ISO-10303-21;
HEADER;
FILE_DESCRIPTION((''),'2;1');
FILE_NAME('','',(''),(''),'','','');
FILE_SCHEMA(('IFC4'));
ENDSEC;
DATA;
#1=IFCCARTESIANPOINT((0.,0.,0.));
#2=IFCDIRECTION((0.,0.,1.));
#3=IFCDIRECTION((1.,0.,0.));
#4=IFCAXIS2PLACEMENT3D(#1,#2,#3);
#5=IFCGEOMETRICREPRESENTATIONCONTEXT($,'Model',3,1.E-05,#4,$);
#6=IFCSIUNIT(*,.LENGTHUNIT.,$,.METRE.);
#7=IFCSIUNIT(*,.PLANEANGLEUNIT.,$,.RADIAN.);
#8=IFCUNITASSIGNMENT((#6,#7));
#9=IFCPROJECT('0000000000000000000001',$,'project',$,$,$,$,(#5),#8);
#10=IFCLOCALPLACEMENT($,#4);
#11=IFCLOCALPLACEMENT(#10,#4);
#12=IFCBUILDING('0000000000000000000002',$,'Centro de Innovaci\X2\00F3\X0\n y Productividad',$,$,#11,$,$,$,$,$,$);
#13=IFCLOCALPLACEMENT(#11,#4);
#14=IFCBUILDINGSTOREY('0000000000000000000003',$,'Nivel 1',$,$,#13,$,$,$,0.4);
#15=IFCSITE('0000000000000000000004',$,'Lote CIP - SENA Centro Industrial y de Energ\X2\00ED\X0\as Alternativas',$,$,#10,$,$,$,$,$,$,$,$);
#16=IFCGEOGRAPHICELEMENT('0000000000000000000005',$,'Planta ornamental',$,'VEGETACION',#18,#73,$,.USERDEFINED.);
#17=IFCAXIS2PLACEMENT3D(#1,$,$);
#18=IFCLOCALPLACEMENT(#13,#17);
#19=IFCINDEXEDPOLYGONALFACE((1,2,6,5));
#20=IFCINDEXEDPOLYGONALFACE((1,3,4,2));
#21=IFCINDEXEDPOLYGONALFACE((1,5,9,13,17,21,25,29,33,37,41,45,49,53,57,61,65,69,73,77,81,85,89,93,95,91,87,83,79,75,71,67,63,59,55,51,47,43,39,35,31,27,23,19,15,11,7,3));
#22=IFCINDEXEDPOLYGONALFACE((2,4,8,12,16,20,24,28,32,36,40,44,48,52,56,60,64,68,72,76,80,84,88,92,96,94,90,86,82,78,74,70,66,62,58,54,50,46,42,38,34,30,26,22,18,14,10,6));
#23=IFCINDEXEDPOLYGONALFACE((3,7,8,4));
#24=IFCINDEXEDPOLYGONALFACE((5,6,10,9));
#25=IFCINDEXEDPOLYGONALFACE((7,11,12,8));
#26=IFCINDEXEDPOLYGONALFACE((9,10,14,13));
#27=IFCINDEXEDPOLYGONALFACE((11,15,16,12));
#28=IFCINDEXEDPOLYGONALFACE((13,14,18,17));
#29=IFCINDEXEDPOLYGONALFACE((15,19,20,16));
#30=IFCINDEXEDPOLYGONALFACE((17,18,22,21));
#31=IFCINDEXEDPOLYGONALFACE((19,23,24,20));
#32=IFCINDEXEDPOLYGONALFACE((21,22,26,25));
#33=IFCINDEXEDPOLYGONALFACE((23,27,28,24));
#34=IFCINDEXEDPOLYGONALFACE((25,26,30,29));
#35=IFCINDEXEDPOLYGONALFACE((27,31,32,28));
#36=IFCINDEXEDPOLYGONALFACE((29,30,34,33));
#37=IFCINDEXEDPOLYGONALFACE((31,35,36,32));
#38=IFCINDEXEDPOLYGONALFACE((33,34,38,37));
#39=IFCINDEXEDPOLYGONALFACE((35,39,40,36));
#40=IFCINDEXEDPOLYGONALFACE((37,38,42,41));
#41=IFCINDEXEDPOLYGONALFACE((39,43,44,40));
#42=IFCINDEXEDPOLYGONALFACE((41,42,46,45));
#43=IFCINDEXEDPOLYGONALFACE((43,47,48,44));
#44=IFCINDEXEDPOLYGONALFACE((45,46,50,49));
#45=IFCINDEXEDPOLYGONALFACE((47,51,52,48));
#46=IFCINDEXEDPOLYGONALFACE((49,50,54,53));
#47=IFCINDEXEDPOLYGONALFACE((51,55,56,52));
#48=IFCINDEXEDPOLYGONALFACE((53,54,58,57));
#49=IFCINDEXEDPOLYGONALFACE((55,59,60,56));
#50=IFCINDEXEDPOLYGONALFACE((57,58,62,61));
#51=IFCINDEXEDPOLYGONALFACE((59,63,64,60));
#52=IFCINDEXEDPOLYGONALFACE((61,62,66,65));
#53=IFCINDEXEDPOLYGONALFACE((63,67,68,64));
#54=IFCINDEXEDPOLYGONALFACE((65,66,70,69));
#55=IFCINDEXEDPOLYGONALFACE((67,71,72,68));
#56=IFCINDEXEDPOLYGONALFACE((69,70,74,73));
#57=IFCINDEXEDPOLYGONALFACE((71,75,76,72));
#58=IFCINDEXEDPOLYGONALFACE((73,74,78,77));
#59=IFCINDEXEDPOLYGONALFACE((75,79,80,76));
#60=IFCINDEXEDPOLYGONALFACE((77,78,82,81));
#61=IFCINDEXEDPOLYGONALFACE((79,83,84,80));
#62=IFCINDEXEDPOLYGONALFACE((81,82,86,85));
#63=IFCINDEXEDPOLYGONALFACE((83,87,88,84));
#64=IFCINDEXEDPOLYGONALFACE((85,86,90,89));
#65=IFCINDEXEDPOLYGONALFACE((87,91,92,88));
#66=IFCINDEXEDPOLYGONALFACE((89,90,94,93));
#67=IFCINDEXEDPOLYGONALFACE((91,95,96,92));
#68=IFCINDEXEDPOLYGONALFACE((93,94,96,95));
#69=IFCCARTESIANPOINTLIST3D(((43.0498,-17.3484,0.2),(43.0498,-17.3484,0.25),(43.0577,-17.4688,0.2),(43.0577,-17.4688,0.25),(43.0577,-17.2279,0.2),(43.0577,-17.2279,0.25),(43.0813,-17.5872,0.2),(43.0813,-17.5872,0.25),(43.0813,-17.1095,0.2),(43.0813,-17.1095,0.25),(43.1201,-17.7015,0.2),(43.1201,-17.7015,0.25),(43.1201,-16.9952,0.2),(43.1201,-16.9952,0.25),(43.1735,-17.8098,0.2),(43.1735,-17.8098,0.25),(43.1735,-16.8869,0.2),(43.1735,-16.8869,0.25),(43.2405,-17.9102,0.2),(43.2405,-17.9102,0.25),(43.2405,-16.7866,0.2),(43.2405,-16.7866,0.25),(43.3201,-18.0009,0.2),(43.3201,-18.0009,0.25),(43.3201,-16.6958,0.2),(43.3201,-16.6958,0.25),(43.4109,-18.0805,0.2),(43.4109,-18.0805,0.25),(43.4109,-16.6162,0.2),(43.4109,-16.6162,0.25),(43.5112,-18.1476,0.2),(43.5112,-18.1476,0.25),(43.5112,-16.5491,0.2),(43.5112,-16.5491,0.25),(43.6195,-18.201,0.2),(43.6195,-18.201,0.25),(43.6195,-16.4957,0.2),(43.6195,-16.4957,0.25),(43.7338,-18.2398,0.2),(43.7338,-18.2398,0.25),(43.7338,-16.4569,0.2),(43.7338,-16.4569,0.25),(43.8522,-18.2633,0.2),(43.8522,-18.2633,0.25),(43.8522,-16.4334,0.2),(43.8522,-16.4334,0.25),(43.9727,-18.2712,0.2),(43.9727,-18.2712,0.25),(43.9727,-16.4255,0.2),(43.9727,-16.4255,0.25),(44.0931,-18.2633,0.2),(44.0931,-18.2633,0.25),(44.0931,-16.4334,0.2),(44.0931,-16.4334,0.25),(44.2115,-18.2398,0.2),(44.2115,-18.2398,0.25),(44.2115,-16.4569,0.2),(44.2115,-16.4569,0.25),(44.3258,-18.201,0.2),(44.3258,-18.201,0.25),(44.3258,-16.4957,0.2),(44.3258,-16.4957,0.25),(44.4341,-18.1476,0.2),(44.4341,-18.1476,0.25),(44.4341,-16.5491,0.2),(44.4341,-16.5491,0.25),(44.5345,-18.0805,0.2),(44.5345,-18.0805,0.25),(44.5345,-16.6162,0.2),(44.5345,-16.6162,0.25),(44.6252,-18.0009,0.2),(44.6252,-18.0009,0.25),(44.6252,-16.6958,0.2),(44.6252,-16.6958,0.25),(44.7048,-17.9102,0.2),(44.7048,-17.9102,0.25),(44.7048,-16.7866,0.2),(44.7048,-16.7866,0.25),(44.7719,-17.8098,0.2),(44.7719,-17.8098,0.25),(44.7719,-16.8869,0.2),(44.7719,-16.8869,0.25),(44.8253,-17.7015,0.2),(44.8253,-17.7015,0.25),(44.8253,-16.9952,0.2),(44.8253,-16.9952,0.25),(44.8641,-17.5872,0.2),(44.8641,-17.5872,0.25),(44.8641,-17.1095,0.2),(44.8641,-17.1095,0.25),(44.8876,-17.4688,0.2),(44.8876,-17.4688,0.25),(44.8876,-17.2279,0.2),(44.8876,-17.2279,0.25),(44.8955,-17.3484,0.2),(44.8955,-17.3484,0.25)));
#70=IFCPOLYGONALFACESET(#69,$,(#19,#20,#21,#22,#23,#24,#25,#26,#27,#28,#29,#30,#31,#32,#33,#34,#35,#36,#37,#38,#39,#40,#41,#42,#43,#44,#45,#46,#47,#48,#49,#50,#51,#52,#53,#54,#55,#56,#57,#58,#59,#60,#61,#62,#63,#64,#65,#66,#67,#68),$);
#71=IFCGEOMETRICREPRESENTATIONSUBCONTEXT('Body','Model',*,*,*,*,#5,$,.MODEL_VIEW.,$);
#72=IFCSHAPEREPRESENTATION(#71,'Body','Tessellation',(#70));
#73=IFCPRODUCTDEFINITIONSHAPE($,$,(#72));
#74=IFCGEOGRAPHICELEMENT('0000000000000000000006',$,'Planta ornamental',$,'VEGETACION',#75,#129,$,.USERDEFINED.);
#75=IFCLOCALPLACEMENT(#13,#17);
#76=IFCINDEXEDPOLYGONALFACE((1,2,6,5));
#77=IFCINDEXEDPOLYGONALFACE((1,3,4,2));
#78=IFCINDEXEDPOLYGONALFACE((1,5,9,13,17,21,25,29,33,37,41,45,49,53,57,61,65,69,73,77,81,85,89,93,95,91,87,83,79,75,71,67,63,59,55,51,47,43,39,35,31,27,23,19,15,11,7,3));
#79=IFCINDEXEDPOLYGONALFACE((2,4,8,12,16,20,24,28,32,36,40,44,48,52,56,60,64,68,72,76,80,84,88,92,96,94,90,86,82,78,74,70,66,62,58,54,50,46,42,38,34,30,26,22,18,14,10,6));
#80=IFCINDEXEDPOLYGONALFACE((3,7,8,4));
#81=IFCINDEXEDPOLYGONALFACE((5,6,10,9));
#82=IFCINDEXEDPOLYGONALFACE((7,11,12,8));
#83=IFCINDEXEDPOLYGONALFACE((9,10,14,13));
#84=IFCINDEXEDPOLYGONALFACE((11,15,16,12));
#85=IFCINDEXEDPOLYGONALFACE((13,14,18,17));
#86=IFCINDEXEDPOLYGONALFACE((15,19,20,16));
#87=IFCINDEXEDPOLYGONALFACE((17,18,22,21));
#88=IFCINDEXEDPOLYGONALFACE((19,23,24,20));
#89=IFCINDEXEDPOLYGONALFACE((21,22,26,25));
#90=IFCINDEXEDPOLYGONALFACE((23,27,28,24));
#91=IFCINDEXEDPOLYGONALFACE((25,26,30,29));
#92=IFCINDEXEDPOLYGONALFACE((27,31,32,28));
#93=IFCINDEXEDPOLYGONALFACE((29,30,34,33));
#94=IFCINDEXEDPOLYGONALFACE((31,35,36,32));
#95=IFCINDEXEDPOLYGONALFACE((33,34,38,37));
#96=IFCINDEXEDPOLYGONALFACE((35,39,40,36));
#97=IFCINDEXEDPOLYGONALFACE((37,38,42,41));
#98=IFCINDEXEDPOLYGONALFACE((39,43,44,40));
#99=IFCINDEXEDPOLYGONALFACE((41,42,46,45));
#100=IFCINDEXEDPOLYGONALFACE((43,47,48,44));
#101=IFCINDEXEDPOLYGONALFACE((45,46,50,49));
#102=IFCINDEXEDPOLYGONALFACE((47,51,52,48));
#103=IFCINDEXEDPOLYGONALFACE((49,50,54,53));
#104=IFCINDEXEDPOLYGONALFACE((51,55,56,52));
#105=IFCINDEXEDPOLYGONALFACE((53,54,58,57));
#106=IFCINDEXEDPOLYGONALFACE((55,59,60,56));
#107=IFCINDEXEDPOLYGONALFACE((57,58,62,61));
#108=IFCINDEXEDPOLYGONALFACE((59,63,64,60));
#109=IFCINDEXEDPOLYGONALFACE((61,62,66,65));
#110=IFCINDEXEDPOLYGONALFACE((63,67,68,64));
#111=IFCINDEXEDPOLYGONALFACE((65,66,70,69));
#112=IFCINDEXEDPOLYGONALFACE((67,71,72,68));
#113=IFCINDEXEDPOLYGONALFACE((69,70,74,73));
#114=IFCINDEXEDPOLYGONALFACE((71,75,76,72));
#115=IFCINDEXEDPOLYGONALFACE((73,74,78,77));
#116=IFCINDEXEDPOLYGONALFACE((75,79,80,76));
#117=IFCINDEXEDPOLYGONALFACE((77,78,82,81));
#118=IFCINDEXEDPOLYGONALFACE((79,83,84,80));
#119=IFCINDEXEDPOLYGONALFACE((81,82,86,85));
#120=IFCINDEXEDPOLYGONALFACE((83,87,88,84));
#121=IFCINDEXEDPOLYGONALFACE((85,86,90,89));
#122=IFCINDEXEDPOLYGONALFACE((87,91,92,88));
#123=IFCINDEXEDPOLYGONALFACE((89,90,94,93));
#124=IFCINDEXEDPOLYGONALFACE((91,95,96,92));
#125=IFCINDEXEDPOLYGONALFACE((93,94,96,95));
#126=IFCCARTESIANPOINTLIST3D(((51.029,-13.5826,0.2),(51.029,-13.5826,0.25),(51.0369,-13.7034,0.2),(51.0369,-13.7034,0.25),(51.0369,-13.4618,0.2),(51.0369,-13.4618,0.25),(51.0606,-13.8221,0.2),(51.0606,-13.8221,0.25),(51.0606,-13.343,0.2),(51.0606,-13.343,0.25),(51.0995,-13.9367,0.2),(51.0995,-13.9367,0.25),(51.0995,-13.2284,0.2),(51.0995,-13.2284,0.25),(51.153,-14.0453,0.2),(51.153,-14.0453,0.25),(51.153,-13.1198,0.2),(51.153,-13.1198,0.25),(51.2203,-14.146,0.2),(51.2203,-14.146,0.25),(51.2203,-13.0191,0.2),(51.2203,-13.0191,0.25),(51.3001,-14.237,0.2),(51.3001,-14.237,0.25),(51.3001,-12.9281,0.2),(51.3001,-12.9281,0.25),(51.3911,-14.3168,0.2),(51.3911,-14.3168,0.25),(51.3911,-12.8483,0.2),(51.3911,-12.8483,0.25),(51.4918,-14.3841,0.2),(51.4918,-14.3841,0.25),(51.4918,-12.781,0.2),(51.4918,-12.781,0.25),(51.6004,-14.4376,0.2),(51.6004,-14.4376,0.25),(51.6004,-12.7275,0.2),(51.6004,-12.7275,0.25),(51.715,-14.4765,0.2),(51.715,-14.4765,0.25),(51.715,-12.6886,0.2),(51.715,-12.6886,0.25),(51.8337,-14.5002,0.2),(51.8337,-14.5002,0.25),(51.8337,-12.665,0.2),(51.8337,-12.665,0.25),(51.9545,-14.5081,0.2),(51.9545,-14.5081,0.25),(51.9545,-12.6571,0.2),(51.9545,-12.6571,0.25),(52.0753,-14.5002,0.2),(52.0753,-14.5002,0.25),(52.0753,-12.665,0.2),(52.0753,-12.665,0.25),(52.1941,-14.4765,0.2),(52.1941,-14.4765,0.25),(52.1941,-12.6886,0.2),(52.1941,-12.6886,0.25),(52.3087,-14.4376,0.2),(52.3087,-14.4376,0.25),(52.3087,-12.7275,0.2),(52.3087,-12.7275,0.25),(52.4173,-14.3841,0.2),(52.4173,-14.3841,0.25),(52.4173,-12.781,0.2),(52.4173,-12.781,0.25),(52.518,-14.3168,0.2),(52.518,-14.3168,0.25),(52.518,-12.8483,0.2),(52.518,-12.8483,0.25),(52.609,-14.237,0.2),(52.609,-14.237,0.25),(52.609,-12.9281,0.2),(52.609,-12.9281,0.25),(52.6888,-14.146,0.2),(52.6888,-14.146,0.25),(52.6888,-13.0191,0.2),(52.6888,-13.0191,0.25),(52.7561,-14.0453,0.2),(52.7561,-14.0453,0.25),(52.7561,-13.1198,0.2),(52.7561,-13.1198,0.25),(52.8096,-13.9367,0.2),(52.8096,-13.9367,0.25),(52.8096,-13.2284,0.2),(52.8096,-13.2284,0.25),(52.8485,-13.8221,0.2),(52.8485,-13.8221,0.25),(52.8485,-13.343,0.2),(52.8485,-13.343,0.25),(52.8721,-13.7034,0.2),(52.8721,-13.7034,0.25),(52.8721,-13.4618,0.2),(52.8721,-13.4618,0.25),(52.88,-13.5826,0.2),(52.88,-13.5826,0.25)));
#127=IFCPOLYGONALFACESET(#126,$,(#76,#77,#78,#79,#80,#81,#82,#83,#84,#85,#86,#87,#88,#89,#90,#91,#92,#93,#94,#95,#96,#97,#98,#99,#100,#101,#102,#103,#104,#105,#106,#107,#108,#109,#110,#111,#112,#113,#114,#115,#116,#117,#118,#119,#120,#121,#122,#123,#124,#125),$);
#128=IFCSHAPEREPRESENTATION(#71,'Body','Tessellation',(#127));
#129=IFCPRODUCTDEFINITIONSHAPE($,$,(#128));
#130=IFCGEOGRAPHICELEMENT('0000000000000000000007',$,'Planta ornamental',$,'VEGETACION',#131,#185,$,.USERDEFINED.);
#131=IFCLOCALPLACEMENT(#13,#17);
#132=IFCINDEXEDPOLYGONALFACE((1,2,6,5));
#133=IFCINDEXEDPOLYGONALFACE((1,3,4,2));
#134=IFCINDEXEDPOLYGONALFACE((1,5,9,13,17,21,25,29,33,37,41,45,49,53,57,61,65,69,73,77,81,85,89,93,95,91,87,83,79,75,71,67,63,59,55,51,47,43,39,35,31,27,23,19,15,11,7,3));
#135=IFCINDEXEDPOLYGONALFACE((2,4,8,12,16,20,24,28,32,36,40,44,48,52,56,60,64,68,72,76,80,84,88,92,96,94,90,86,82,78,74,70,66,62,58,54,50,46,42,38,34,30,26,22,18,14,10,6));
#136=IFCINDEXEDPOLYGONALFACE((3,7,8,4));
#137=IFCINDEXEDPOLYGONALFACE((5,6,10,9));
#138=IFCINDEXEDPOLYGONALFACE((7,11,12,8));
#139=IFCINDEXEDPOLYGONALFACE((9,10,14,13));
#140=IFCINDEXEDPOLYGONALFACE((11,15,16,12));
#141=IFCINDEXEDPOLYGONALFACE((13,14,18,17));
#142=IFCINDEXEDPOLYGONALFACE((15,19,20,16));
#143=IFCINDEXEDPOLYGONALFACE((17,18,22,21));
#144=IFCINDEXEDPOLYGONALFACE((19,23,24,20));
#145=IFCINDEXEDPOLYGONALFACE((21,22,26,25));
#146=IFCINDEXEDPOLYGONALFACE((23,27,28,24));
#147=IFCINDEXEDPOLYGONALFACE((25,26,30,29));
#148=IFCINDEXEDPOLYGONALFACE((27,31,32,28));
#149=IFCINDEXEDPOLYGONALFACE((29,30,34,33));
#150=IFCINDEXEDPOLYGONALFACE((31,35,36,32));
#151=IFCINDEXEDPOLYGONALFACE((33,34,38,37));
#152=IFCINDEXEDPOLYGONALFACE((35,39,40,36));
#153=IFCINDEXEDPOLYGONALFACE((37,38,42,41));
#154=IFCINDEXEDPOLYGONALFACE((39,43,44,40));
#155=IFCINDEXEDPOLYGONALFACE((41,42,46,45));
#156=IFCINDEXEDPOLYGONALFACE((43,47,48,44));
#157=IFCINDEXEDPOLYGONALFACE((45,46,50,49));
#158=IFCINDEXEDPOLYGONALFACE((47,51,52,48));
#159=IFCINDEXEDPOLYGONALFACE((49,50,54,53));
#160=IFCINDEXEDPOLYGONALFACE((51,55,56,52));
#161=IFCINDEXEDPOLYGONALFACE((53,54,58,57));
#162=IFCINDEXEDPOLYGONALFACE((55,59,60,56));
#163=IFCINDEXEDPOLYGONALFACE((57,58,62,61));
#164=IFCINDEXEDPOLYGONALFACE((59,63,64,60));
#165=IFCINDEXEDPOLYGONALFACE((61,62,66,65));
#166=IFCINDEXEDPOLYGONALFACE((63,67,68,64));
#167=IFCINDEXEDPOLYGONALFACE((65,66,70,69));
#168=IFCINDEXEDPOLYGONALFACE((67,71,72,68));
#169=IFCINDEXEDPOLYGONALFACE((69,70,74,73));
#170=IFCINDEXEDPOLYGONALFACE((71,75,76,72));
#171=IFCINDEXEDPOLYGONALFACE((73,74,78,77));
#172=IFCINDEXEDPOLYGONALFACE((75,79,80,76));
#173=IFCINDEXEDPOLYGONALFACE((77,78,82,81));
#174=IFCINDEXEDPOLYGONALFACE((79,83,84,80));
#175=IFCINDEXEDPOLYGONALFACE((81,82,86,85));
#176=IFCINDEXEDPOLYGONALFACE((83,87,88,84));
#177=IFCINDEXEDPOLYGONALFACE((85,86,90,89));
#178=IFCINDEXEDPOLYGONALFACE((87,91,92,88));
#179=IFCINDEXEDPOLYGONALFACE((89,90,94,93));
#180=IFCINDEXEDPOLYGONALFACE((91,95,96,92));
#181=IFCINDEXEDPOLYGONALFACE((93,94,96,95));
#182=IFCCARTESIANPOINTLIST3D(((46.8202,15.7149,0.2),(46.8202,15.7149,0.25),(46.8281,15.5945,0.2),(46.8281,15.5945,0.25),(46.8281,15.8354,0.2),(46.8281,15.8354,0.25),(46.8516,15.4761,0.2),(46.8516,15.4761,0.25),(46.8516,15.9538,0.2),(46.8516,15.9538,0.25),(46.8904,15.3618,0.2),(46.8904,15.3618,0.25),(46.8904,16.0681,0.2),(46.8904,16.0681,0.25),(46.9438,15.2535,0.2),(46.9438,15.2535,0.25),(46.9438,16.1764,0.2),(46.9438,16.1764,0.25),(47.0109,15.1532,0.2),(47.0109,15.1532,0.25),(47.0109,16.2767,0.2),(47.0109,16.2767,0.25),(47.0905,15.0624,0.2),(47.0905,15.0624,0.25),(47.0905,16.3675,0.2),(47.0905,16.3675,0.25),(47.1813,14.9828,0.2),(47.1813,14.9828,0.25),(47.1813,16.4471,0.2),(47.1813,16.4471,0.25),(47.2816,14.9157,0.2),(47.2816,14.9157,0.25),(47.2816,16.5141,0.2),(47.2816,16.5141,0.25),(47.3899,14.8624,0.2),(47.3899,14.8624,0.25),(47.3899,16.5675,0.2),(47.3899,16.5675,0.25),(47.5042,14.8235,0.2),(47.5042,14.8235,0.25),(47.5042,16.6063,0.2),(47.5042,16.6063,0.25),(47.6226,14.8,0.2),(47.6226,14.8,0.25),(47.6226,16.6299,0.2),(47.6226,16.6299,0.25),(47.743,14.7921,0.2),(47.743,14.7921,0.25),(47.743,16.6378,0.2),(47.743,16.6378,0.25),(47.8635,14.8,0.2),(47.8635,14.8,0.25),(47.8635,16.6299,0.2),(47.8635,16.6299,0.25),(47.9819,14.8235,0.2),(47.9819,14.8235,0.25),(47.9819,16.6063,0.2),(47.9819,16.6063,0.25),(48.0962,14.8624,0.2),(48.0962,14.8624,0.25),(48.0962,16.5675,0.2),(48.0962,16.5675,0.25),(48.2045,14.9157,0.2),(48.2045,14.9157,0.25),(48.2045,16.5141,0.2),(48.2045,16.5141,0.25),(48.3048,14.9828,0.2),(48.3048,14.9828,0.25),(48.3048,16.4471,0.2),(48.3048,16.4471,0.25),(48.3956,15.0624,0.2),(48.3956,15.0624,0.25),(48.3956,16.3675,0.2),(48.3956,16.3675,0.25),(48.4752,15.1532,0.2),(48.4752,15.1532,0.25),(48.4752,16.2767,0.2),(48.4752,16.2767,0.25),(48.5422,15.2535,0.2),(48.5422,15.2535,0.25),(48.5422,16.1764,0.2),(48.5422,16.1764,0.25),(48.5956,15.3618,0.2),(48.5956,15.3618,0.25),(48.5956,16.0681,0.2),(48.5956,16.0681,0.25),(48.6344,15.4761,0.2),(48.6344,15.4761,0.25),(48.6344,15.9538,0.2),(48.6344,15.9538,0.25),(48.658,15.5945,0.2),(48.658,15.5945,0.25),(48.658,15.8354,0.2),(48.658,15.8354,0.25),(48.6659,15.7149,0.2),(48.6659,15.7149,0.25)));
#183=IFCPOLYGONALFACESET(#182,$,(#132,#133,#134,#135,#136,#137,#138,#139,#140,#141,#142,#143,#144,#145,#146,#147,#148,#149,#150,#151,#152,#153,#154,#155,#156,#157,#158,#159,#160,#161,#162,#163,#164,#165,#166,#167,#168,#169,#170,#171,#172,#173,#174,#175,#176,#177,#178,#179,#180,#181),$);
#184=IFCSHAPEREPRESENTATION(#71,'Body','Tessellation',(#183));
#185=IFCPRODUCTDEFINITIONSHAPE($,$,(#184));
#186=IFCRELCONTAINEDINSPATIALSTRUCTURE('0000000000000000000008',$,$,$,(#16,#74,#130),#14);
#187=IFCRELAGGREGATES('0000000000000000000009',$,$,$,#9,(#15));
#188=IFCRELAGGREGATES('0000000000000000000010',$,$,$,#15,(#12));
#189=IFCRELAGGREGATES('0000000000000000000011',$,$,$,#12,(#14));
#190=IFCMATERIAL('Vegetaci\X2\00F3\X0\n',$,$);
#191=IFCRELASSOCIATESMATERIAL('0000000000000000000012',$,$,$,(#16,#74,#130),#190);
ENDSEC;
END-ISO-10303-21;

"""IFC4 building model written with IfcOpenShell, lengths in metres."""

from ifc_helpers import new_model, si_unit, frame, origin_with_axes, place, context, subcontext, project, spatial, polyline, outline, extrude, material, element, save


model = new_model("IFC4")

# Units and contexts
model_context = context("Model", 3, precision=1e-05, world=origin_with_axes())
body_context = subcontext(model_context, "Body", "Model", "MODEL_VIEW")
ifc_project = project(units=[si_unit("LENGTHUNIT", "METRE"), si_unit("PLANEANGLEUNIT", "RADIAN")], contexts=[model_context])

# Site, building, storey
site_placement = place(None, origin_with_axes())
site = spatial("IfcSite", under=ifc_project, at=site_placement, Name="Lote CIP - SENA Centro Industrial y de Energías Alternativas")
building_placement = place(site_placement, origin_with_axes())
building = spatial("IfcBuilding", under=site, at=building_placement, Name="Centro de Innovación y Productividad")
storey_placement = place(building_placement, origin_with_axes())
storey = spatial("IfcBuildingStorey", under=building, at=storey_placement, Name="Nivel 1", Elevation=0.4)

# Geographic elements
ifc_material = material(Name="Vegetación")
geographic_element_1_placement = place(storey_placement, origin_with_axes())
element("IfcGeographicElement", 1, at=geographic_element_1_placement, inside=storey, material=ifc_material, Name="Planta ornamental", ObjectType="VEGETACION", PredefinedType="USERDEFINED", context=body_context, shape_type="SweptSolid", body=[
    extrude(outline(polyline([(44.8955, -17.3484), (44.8876, -17.4688), (44.8641, -17.5872), (44.8253, -17.7015), (44.7719, -17.8098), (44.7048, -17.9102), (44.6252, -18.0009), (44.5345, -18.0805), (44.4341, -18.1476), (44.3258, -18.201), (44.2115, -18.2398), (44.0931, -18.2633), (43.9727, -18.2712), (43.8522, -18.2633), (43.7338, -18.2398), (43.6195, -18.201), (43.5112, -18.1476), (43.4109, -18.0805), (43.3201, -18.0009), (43.2405, -17.9102), (43.1735, -17.8098), (43.1201, -17.7015), (43.0813, -17.5872), (43.0577, -17.4688), (43.0498, -17.3484), (43.0577, -17.2279), (43.0813, -17.1095), (43.1201, -16.9952), (43.1735, -16.8869), (43.2405, -16.7866), (43.3201, -16.6958), (43.4109, -16.6162), (43.5112, -16.5491), (43.6195, -16.4957), (43.7338, -16.4569), (43.8522, -16.4334), (43.9727, -16.4255), (44.0931, -16.4334), (44.2115, -16.4569), (44.3258, -16.4957), (44.4341, -16.5491), (44.5345, -16.6162), (44.6252, -16.6958), (44.7048, -16.7866), (44.7719, -16.8869), (44.8253, -16.9952), (44.8641, -17.1095), (44.8876, -17.2279), (44.8955, -17.3484)])), frame((0.0, 0.0, 0.2)), (0.0, 0.0, 1.0), 0.05),
])
geographic_element_2_placement = place(storey_placement, origin_with_axes())
element("IfcGeographicElement", 2, at=geographic_element_2_placement, inside=storey, material=ifc_material, Name="Planta ornamental", ObjectType="VEGETACION", PredefinedType="USERDEFINED", context=body_context, shape_type="SweptSolid", body=[
    extrude(outline(polyline([(52.88, -13.5826), (52.8721, -13.7034), (52.8485, -13.8221), (52.8096, -13.9367), (52.7561, -14.0453), (52.6888, -14.146), (52.609, -14.237), (52.518, -14.3168), (52.4173, -14.3841), (52.3087, -14.4376), (52.1941, -14.4765), (52.0753, -14.5002), (51.9545, -14.5081), (51.8337, -14.5002), (51.715, -14.4765), (51.6004, -14.4376), (51.4918, -14.3841), (51.3911, -14.3168), (51.3001, -14.237), (51.2203, -14.146), (51.153, -14.0453), (51.0995, -13.9367), (51.0606, -13.8221), (51.0369, -13.7034), (51.029, -13.5826), (51.0369, -13.4618), (51.0606, -13.343), (51.0995, -13.2284), (51.153, -13.1198), (51.2203, -13.0191), (51.3001, -12.9281), (51.3911, -12.8483), (51.4918, -12.781), (51.6004, -12.7275), (51.715, -12.6886), (51.8337, -12.665), (51.9545, -12.6571), (52.0753, -12.665), (52.1941, -12.6886), (52.3087, -12.7275), (52.4173, -12.781), (52.518, -12.8483), (52.609, -12.9281), (52.6888, -13.0191), (52.7561, -13.1198), (52.8096, -13.2284), (52.8485, -13.343), (52.8721, -13.4618), (52.88, -13.5826)])), frame((0.0, 0.0, 0.2)), (0.0, 0.0, 1.0), 0.05),
])
geographic_element_3_placement = place(storey_placement, origin_with_axes())
element("IfcGeographicElement", 3, at=geographic_element_3_placement, inside=storey, material=ifc_material, Name="Planta ornamental", ObjectType="VEGETACION", PredefinedType="USERDEFINED", context=body_context, shape_type="SweptSolid", body=[
    extrude(outline(polyline([(48.6659, 15.7149), (48.658, 15.5945), (48.6344, 15.4761), (48.5956, 15.3618), (48.5422, 15.2535), (48.4752, 15.1532), (48.3956, 15.0624), (48.3048, 14.9828), (48.2045, 14.9157), (48.0962, 14.8624), (47.9819, 14.8235), (47.8635, 14.8), (47.743, 14.7921), (47.6226, 14.8), (47.5042, 14.8235), (47.3899, 14.8624), (47.2816, 14.9157), (47.1813, 14.9828), (47.0905, 15.0624), (47.0109, 15.1532), (46.9438, 15.2535), (46.8904, 15.3618), (46.8516, 15.4761), (46.8281, 15.5945), (46.8202, 15.7149), (46.8281, 15.8354), (46.8516, 15.9538), (46.8904, 16.0681), (46.9438, 16.1764), (47.0109, 16.2767), (47.0905, 16.3675), (47.1813, 16.4471), (47.2816, 16.5141), (47.3899, 16.5675), (47.5042, 16.6063), (47.6226, 16.6299), (47.743, 16.6378), (47.8635, 16.6299), (47.9819, 16.6063), (48.0962, 16.5675), (48.2045, 16.5141), (48.3048, 16.4471), (48.3956, 16.3675), (48.4752, 16.2767), (48.5422, 16.1764), (48.5956, 16.0681), (48.6344, 15.9538), (48.658, 15.8354), (48.6659, 15.7149)])), frame((0.0, 0.0, 0.2)), (0.0, 0.0, 1.0), 0.05),
])

save(model, "model.ifc")
